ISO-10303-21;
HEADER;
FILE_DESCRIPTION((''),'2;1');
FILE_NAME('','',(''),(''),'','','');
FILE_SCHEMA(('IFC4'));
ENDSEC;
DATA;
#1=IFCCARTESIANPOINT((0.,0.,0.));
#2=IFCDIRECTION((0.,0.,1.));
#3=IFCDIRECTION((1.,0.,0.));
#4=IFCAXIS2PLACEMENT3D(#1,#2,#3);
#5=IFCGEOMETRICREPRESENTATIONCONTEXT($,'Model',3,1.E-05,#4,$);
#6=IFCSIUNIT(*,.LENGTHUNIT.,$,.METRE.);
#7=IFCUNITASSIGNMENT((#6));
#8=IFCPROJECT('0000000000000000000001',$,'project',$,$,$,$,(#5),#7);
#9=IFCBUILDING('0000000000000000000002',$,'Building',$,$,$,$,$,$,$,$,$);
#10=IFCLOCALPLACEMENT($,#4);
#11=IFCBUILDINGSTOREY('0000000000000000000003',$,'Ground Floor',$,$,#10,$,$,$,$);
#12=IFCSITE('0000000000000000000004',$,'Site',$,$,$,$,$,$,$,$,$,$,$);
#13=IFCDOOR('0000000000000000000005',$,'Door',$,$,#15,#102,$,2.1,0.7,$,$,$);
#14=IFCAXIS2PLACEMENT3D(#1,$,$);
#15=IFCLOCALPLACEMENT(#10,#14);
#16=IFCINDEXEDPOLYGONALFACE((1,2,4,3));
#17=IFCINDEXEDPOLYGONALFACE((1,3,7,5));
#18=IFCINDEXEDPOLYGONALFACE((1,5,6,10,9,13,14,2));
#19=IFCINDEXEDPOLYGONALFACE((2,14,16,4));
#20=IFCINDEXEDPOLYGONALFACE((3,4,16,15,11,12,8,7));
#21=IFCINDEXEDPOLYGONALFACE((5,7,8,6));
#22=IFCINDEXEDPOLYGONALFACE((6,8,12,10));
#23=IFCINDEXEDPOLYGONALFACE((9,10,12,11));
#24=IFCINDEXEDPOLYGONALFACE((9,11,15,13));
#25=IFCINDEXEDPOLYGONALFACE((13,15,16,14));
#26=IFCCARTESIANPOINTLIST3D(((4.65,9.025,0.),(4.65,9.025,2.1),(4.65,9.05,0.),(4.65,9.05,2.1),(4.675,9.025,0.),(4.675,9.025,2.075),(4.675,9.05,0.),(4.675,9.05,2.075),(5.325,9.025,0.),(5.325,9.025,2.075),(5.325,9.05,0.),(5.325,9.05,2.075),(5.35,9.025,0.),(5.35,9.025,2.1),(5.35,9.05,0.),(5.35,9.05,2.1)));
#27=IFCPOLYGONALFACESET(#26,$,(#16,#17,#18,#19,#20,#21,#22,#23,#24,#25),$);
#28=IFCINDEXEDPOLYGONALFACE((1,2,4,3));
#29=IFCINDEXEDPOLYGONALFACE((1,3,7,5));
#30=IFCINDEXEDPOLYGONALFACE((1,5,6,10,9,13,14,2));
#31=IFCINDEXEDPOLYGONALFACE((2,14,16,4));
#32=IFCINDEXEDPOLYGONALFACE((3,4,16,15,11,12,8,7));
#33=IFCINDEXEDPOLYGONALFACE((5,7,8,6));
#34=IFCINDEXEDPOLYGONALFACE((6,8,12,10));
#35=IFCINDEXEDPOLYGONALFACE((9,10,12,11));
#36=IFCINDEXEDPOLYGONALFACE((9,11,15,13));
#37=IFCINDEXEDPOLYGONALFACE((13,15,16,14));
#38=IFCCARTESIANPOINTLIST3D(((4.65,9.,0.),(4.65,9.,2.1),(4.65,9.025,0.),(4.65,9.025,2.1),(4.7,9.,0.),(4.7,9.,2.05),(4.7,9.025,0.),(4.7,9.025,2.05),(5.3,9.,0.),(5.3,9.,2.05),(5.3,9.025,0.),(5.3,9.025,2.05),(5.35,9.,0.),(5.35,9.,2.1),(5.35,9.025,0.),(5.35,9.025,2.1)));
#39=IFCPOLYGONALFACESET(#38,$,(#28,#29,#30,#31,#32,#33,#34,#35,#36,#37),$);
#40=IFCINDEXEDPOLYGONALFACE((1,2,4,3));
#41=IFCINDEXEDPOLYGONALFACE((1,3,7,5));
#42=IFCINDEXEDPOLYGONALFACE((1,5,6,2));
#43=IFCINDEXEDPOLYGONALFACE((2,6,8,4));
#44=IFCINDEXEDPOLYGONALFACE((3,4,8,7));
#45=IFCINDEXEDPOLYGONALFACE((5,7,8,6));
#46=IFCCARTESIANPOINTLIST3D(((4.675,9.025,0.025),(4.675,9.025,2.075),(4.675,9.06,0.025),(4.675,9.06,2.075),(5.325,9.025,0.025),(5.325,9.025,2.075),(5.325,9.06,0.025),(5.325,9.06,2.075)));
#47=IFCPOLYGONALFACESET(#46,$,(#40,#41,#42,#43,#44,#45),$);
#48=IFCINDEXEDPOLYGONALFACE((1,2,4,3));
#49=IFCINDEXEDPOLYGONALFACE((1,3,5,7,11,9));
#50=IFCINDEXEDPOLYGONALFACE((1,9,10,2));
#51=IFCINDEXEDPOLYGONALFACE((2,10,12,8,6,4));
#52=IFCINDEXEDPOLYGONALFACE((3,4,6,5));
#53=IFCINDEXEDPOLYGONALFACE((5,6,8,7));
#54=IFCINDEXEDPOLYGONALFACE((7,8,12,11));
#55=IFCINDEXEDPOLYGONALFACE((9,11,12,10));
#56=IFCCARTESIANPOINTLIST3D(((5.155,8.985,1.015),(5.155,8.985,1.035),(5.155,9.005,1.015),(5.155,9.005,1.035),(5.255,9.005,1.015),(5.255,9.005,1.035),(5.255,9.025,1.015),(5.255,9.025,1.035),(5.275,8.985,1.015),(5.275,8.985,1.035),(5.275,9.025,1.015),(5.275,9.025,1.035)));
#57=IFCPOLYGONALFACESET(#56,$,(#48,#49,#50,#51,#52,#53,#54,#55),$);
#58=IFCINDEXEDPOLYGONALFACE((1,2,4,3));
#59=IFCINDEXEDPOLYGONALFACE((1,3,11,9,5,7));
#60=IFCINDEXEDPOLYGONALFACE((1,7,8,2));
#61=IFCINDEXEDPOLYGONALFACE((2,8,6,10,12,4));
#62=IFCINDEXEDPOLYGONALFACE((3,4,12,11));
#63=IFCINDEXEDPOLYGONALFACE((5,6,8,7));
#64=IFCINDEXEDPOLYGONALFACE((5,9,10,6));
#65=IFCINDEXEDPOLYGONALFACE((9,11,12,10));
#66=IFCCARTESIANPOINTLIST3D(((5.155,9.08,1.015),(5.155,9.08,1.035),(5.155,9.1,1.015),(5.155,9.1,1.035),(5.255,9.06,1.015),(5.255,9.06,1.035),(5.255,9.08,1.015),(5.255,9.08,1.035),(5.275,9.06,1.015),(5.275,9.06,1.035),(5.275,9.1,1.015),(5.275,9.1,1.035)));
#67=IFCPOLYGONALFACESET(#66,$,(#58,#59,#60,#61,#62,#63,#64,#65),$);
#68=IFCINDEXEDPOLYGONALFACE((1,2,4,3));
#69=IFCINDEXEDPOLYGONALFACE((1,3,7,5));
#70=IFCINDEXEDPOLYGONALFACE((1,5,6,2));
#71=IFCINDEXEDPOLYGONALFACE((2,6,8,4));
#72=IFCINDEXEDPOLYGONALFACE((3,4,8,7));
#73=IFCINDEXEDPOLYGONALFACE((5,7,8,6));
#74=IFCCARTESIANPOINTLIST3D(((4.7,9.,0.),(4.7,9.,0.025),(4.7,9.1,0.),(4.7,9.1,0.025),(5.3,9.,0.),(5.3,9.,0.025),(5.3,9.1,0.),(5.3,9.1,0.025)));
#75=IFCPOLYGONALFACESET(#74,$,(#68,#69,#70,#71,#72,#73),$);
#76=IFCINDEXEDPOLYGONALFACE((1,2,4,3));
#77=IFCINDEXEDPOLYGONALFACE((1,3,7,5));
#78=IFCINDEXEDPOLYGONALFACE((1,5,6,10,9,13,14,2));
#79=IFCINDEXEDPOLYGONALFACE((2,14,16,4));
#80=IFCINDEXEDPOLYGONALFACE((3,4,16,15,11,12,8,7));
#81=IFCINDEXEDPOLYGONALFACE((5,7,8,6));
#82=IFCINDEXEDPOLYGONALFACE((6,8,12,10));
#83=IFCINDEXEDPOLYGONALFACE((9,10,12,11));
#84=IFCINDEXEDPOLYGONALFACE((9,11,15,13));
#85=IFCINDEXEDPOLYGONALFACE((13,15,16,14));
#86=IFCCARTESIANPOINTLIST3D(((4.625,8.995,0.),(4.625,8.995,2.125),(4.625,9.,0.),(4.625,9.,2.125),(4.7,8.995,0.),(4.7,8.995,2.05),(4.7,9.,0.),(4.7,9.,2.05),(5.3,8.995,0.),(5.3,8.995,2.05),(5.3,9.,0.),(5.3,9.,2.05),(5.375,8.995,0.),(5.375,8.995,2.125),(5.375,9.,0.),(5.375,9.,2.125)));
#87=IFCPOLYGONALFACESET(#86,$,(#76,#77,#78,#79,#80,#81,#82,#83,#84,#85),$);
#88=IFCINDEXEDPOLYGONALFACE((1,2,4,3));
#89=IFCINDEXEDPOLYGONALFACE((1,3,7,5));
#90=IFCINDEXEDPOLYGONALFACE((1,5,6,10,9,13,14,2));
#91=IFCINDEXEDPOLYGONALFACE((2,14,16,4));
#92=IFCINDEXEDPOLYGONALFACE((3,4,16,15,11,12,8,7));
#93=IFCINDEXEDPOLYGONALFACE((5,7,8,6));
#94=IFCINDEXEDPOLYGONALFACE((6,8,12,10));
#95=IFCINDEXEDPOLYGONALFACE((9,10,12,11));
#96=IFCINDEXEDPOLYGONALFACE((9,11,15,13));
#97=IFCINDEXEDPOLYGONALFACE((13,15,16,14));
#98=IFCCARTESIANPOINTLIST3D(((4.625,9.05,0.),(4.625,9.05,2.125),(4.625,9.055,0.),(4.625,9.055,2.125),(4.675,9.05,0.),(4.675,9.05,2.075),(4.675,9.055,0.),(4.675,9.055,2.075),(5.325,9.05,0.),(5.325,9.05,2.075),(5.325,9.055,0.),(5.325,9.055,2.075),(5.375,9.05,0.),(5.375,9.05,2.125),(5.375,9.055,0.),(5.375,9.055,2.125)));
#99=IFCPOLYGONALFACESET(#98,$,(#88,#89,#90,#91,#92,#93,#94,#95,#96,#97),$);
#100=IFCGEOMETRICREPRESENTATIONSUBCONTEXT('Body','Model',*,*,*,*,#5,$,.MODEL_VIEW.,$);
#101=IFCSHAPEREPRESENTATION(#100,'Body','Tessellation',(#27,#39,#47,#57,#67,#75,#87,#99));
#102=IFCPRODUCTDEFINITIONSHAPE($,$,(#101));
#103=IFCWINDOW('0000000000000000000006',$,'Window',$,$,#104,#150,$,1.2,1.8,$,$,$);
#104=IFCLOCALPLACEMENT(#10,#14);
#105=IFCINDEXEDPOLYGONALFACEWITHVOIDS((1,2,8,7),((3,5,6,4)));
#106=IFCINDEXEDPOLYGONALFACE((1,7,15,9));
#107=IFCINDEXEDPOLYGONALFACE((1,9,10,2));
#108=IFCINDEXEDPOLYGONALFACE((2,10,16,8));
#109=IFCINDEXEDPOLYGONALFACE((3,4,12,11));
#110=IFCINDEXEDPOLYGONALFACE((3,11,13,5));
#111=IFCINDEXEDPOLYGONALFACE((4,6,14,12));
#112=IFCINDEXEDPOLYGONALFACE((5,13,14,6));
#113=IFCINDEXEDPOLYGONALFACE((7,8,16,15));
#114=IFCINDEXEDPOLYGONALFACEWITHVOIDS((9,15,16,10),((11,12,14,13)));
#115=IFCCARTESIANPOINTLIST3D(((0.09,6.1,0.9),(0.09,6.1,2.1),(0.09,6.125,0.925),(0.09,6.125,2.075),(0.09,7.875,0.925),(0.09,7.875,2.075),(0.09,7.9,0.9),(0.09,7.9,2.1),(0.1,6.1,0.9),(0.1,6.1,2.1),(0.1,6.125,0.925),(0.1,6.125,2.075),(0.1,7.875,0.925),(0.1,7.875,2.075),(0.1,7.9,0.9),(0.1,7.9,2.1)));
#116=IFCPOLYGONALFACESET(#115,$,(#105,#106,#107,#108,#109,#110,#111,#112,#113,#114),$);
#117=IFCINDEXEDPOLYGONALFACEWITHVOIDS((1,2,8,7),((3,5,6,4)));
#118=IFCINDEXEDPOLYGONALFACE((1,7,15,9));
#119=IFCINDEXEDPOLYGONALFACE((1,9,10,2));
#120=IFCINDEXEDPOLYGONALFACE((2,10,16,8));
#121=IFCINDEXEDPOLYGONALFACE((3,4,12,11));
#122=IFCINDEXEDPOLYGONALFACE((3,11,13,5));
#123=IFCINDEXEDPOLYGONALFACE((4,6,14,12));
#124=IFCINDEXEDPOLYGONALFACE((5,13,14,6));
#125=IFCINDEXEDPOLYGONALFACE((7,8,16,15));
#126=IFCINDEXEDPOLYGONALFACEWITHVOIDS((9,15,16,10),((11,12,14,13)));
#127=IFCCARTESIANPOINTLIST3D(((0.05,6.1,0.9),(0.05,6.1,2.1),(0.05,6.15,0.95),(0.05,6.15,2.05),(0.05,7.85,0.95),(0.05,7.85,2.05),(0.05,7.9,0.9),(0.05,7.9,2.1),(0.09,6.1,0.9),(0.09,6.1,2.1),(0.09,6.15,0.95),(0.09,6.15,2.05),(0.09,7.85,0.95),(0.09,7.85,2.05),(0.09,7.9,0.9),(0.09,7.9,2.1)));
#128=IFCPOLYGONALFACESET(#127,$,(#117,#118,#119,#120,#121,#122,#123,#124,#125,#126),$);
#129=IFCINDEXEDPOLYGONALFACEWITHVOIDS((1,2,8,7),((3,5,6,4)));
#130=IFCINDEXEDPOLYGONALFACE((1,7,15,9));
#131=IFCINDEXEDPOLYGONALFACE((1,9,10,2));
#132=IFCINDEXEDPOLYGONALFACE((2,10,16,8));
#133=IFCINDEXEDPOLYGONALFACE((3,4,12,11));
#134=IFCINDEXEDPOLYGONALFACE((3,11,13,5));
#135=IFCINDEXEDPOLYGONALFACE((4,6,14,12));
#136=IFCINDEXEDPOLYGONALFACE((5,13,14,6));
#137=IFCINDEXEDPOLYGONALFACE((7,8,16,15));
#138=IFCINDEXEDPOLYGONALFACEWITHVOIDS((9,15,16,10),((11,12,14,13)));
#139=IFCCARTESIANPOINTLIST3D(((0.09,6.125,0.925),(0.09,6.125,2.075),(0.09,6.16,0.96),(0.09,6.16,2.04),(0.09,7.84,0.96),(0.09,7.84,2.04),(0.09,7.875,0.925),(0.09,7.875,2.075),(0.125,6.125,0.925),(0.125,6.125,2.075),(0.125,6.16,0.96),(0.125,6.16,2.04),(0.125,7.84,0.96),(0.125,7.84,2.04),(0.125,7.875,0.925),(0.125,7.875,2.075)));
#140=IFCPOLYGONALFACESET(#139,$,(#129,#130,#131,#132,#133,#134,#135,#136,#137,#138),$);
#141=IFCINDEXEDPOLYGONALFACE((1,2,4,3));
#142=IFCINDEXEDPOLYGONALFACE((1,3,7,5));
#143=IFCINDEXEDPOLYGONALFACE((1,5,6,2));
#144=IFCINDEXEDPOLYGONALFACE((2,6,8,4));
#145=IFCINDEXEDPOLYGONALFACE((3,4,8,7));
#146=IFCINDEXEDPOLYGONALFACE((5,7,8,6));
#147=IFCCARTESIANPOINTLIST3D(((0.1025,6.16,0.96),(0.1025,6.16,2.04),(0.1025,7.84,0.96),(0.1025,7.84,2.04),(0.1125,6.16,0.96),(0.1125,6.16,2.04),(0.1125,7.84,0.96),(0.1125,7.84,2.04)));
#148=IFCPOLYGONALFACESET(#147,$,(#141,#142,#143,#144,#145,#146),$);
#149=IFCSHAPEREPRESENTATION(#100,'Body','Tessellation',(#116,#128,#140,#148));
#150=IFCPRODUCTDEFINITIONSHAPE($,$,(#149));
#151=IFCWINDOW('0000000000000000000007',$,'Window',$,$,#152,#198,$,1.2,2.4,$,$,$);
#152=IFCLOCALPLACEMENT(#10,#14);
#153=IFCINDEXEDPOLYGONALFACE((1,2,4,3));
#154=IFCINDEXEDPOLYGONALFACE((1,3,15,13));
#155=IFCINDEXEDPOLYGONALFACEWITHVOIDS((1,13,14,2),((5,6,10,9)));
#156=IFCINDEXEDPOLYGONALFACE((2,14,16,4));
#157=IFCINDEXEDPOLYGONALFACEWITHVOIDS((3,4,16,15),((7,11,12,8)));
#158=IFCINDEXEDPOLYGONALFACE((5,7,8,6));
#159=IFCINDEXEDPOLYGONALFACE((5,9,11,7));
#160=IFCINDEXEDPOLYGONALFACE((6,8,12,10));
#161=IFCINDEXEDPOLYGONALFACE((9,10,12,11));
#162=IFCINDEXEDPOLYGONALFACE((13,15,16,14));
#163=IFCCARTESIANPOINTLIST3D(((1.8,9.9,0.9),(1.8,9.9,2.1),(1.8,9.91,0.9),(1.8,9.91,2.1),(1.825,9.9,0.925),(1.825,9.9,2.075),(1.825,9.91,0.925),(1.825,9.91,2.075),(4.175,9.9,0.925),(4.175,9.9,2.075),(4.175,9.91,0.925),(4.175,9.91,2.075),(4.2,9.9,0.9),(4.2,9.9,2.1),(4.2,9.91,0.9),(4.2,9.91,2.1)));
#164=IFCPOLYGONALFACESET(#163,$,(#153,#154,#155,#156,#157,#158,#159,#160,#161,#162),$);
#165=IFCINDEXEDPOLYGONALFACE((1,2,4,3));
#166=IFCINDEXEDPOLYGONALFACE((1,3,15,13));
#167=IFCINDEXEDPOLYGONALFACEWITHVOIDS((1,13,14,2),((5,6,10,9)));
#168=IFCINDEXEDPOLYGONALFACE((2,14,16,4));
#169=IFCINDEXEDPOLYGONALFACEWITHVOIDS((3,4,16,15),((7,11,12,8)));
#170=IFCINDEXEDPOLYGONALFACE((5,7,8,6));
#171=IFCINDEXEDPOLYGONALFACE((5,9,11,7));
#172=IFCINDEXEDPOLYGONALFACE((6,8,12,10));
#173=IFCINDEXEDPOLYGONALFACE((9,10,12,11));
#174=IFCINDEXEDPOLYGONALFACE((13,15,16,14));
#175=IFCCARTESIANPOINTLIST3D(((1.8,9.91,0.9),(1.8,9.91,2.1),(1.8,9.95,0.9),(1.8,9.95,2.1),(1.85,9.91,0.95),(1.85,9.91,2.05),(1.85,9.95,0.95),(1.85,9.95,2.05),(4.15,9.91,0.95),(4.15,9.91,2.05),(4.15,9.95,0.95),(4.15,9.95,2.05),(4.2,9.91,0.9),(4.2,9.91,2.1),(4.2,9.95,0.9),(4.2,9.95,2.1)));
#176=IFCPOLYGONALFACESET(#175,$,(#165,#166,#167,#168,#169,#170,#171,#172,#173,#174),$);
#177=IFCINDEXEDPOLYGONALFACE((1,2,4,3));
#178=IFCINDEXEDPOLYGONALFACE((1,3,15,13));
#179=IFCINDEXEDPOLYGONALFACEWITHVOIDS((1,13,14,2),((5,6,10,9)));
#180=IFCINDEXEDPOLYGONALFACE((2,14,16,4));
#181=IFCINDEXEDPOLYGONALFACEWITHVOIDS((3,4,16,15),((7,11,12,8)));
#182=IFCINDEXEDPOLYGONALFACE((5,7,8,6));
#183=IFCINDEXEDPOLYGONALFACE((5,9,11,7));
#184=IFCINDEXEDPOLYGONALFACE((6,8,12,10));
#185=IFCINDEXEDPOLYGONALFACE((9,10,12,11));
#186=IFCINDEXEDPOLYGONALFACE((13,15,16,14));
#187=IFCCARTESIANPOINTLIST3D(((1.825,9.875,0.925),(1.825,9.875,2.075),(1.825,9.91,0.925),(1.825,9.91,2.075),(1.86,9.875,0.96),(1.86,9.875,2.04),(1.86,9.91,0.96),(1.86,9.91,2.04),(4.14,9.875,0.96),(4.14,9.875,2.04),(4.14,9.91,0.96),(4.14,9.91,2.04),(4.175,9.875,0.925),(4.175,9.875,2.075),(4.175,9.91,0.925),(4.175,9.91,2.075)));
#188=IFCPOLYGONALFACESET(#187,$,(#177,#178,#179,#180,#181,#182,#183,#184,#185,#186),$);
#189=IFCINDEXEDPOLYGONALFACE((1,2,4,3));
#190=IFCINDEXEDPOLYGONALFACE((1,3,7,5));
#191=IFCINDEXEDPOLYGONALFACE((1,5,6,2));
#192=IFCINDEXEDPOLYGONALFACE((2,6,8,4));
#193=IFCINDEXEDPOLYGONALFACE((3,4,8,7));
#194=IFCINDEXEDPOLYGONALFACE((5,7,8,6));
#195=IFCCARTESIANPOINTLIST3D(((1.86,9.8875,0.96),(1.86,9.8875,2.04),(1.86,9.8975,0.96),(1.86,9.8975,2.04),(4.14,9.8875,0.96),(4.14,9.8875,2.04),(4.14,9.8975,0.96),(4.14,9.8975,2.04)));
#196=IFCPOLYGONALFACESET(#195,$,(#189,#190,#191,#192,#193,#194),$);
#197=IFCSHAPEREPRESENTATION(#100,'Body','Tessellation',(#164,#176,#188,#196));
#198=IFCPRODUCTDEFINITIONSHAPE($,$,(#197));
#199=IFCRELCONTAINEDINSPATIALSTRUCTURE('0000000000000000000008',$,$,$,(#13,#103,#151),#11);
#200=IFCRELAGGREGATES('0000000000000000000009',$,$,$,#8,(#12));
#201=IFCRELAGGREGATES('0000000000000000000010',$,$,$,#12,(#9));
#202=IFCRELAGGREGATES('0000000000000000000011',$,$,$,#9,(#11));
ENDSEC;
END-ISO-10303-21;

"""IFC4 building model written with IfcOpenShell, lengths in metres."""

from ifc_helpers import new_model, si_unit, frame, origin_with_axes, place, context, subcontext, project, spatial, line, indexed_curve, outline, extrude, element, save


model = new_model("IFC4")

# Units and contexts
model_context = context("Model", 3, precision=1e-05, world=origin_with_axes())
body_context = subcontext(model_context, "Body", "Model", "MODEL_VIEW")
ifc_project = project(units=[si_unit("LENGTHUNIT", "METRE")], contexts=[model_context])

# Site, building, storey
site = spatial("IfcSite", under=ifc_project, Name="Site")
building = spatial("IfcBuilding", under=site, Name="Building")
storey_placement = place(None, origin_with_axes())
storey = spatial("IfcBuildingStorey", under=building, at=storey_placement, Name="Ground Floor")

# Door
door_1_placement = place(storey_placement, frame((4.65, 9.0, 0.0), z_axis=(0.0, 0.0, 1.0), x_axis=(1.0, 0.0, 0.0)))
element("IfcDoor", 1, at=door_1_placement, inside=storey, Name="Door", OverallHeight=2.1, OverallWidth=0.7, context=body_context, shape_type="SweptSolid", body=[
    extrude(outline(indexed_curve([(0.0, 0.0), (0.0, 2.1), (0.7, 2.1), (0.7, 0.0), (0.675, 0.0), (0.675, 2.075), (0.025, 2.075), (0.025, 0.0)], segments=[line(1, 2, 3, 4, 5, 6, 7, 8, 1)])), frame((0.0, 0.025, 0.0), z_axis=(0.0, -1.0, 0.0), x_axis=(1.0, 0.0, 0.0)), (0.0, 0.0, -1.0), 0.025),
    extrude(outline(indexed_curve([(0.0, 0.0), (0.0, 2.1), (0.7, 2.1), (0.7, 0.0), (0.65, 0.0), (0.65, 2.05), (0.05, 2.05), (0.05, 0.0)], segments=[line(1, 2, 3, 4, 5, 6, 7, 8, 1)])), frame((0.0, 0.0, 0.0), z_axis=(0.0, -1.0, 0.0), x_axis=(1.0, 0.0, 0.0)), (0.0, 0.0, -1.0), 0.025),
    extrude(outline(indexed_curve([(0.0, 0.0), (0.65, 0.0), (0.65, 0.035), (0.0, 0.035)], segments=[line(1, 2, 3, 4, 1)])), frame((0.025, 0.025, 0.025), z_axis=(0.0, 0.0, 1.0), x_axis=(1.0, 0.0, 0.0)), (0.0, 0.0, 1.0), 2.05),
    extrude(outline(indexed_curve([(0.0, 0.0), (0.0, -0.04), (-0.12, -0.04), (-0.12, -0.02), (-0.02, -0.02), (-0.02, 0.0)], segments=[line(1, 2, 3, 4, 5, 6, 1)])), frame((0.625, 0.025, 1.015), z_axis=(0.0, 0.0, 1.0), x_axis=(1.0, 0.0, 0.0)), (0.0, 0.0, 1.0), 0.02),
    extrude(outline(indexed_curve([(0.0, 0.0), (0.0, 0.04), (-0.12, 0.04), (-0.12, 0.02), (-0.02, 0.02), (-0.02, 0.0)], segments=[line(1, 2, 3, 4, 5, 6, 1)])), frame((0.625, 0.06, 1.015), z_axis=(0.0, 0.0, 1.0), x_axis=(1.0, 0.0, 0.0)), (0.0, 0.0, 1.0), 0.02),
    extrude(outline(indexed_curve([(0.0, 0.0), (0.6, 0.0), (0.6, 0.1), (0.0, 0.1)], segments=[line(1, 2, 3, 4, 1)])), frame((0.05, 0.0, 0.0), z_axis=(0.0, 0.0, 1.0), x_axis=(1.0, 0.0, 0.0)), (0.0, 0.0, 1.0), 0.025),
    extrude(outline(indexed_curve([(0.0, 0.0), (0.0, 2.125), (0.75, 2.125), (0.75, 0.0), (0.675, 0.0), (0.675, 2.05), (0.075, 2.05), (0.075, 0.0)], segments=[line(1, 2, 3, 4, 5, 6, 7, 8, 1)])), frame((-0.025, -0.005, 0.0), z_axis=(0.0, -1.0, 0.0), x_axis=(1.0, 0.0, 0.0)), (0.0, 0.0, -1.0), 0.005),
    extrude(outline(indexed_curve([(0.0, 0.0), (0.0, 2.125), (0.75, 2.125), (0.75, 0.0), (0.7, 0.0), (0.7, 2.075), (0.05, 2.075), (0.05, 0.0)], segments=[line(1, 2, 3, 4, 5, 6, 7, 8, 1)])), frame((-0.025, 0.05, 0.0), z_axis=(0.0, -1.0, 0.0), x_axis=(1.0, 0.0, 0.0)), (0.0, 0.0, -1.0), 0.005),
])

# Windows
window_1_placement = place(storey_placement, frame((0.0, 7.9, 0.9), z_axis=(0.0, 0.0, 1.0), x_axis=(0.0, -1.0, 0.0)))
element("IfcWindow", 2, at=window_1_placement, inside=storey, Name="Window", OverallHeight=1.2, OverallWidth=1.8, context=body_context, shape_type="SweptSolid", body=[
    extrude(outline(indexed_curve([(0.0, 0.0), (1.8, 0.0), (1.8, 1.2), (0.0, 1.2)], segments=[line(1, 2, 3, 4, 1)]), holes=[indexed_curve([(0.025, 0.025), (1.775, 0.025), (1.775, 1.175), (0.025, 1.175)], segments=[line(1, 2, 3, 4, 1)])]), frame((0.0, 0.09, 0.0), z_axis=(0.0, -1.0, 0.0), x_axis=(1.0, 0.0, 0.0)), (0.0, 0.0, -1.0), 0.01),
    extrude(outline(indexed_curve([(0.0, 0.0), (1.8, 0.0), (1.8, 1.2), (0.0, 1.2)], segments=[line(1, 2, 3, 4, 1)]), holes=[indexed_curve([(0.05, 0.05), (1.75, 0.05), (1.75, 1.15), (0.05, 1.15)], segments=[line(1, 2, 3, 4, 1)])]), frame((0.0, 0.05, 0.0), z_axis=(0.0, -1.0, 0.0), x_axis=(1.0, 0.0, 0.0)), (0.0, 0.0, -1.0), 0.04),
    extrude(outline(indexed_curve([(0.0, 0.0), (1.75, 0.0), (1.75, 1.15), (0.0, 1.15)], segments=[line(1, 2, 3, 4, 1)]), holes=[indexed_curve([(0.035, 0.035), (1.715, 0.035), (1.715, 1.115), (0.035, 1.115)], segments=[line(1, 2, 3, 4, 1)])]), frame((0.025, 0.09, 0.025), z_axis=(0.0, -1.0, 0.0), x_axis=(1.0, 0.0, 0.0)), (0.0, 0.0, -1.0), 0.035),
    extrude(outline(indexed_curve([(0.035, 0.035), (1.715, 0.035), (1.715, 1.115), (0.035, 1.115)], segments=[line(1, 2, 3, 4, 1)])), frame((0.025, 0.1025, 0.025), z_axis=(0.0, -1.0, 0.0), x_axis=(1.0, 0.0, 0.0)), (0.0, 0.0, -1.0), 0.01),
])
window_2_placement = place(storey_placement, frame((4.2, 10.0, 0.9), z_axis=(0.0, 0.0, 1.0), x_axis=(-1.0, 0.0, 0.0)))
element("IfcWindow", 3, at=window_2_placement, inside=storey, Name="Window", OverallHeight=1.2, OverallWidth=2.4, context=body_context, shape_type="SweptSolid", body=[
    extrude(outline(indexed_curve([(0.0, 0.0), (2.4, 0.0), (2.4, 1.2), (0.0, 1.2)], segments=[line(1, 2, 3, 4, 1)]), holes=[indexed_curve([(0.025, 0.025), (2.375, 0.025), (2.375, 1.175), (0.025, 1.175)], segments=[line(1, 2, 3, 4, 1)])]), frame((0.0, 0.09, 0.0), z_axis=(0.0, -1.0, 0.0), x_axis=(1.0, 0.0, 0.0)), (0.0, 0.0, -1.0), 0.01),
    extrude(outline(indexed_curve([(0.0, 0.0), (2.4, 0.0), (2.4, 1.2), (0.0, 1.2)], segments=[line(1, 2, 3, 4, 1)]), holes=[indexed_curve([(0.05, 0.05), (2.35, 0.05), (2.35, 1.15), (0.05, 1.15)], segments=[line(1, 2, 3, 4, 1)])]), frame((0.0, 0.05, 0.0), z_axis=(0.0, -1.0, 0.0), x_axis=(1.0, 0.0, 0.0)), (0.0, 0.0, -1.0), 0.04),
    extrude(outline(indexed_curve([(0.0, 0.0), (2.35, 0.0), (2.35, 1.15), (0.0, 1.15)], segments=[line(1, 2, 3, 4, 1)]), holes=[indexed_curve([(0.035, 0.035), (2.315, 0.035), (2.315, 1.115), (0.035, 1.115)], segments=[line(1, 2, 3, 4, 1)])]), frame((0.025, 0.09, 0.025), z_axis=(0.0, -1.0, 0.0), x_axis=(1.0, 0.0, 0.0)), (0.0, 0.0, -1.0), 0.035),
    extrude(outline(indexed_curve([(0.035, 0.035), (2.315, 0.035), (2.315, 1.115), (0.035, 1.115)], segments=[line(1, 2, 3, 4, 1)])), frame((0.025, 0.1025, 0.025), z_axis=(0.0, -1.0, 0.0), x_axis=(1.0, 0.0, 0.0)), (0.0, 0.0, -1.0), 0.01),
])

save(model, "model.ifc")
